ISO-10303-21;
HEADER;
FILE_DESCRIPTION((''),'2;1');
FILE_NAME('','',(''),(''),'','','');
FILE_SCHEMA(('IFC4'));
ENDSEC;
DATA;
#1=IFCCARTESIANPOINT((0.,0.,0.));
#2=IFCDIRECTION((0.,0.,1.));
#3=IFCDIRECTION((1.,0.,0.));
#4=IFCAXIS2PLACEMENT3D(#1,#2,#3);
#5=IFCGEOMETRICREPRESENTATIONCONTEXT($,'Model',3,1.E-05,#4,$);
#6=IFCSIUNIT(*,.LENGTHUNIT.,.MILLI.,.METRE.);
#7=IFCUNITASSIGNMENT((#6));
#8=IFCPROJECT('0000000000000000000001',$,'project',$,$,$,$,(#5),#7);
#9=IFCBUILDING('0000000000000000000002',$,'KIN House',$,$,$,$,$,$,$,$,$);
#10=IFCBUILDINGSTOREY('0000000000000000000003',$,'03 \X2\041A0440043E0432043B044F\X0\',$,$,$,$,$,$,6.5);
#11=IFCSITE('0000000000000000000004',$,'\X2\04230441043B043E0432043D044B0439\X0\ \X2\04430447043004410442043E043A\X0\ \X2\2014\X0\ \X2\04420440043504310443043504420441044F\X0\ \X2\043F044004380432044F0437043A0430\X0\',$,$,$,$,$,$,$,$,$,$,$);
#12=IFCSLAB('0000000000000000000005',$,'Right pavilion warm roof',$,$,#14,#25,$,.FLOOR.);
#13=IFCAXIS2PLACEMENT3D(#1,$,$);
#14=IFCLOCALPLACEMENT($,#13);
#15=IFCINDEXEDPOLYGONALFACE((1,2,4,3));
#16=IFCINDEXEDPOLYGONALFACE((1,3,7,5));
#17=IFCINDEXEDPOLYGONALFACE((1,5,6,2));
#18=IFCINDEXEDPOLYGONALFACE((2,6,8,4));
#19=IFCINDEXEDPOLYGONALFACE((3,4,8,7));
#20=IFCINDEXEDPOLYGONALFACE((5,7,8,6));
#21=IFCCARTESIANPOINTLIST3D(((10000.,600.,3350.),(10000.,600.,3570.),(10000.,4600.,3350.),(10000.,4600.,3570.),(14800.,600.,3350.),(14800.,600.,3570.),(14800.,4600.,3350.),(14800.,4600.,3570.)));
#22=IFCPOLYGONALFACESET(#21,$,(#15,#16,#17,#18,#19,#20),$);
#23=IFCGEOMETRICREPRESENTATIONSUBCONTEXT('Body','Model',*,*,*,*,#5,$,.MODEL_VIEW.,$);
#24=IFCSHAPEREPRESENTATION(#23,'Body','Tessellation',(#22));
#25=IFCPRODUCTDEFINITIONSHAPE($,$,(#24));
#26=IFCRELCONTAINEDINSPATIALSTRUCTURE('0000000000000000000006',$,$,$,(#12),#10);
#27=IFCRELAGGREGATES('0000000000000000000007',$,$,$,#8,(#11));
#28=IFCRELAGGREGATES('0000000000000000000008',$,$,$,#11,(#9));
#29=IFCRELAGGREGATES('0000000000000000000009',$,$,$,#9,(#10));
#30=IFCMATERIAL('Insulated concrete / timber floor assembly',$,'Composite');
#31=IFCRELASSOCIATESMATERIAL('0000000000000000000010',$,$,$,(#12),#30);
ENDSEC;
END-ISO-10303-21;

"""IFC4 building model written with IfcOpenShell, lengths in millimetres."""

from ifc_helpers import new_model, si_unit, frame, origin_with_axes, place, context, subcontext, project, spatial, indexed_curve, outline, extrude, material, element, save


model = new_model("IFC4")

# Units and contexts
model_context = context("Model", 3, precision=1e-05, world=origin_with_axes())
body_context = subcontext(model_context, "Body", "Model", "MODEL_VIEW")
ifc_project = project(units=[si_unit("LENGTHUNIT", "METRE", prefix="MILLI")], contexts=[model_context])

# Site, building, storey
site = spatial("IfcSite", under=ifc_project, Name="Условный участок — требуется привязка")
building = spatial("IfcBuilding", under=site, Name="KIN House")
storey = spatial("IfcBuildingStorey", under=building, Name="03 Кровля", Elevation=6.5)

# Slab
ifc_material = material(Name="Insulated concrete / timber floor assembly", Category="Composite")
slab_placement = place(None, frame((10000.0, 600.0, 3350.0), z_axis=(0.0, 0.0, 1.0), x_axis=(1.0, 0.0, 0.0)))
element("IfcSlab", 1, at=slab_placement, inside=storey, material=ifc_material, Name="Right pavilion warm roof", PredefinedType="FLOOR", context=body_context, shape_type="SweptSolid", body=[
    extrude(outline(indexed_curve([(0.0, 0.0), (4800.0, 0.0), (4800.0, 4000.0), (0.0, 4000.0)])), None, (0.0, 0.0, 1.0), 220.0),
])

save(model, "model.ifc")
